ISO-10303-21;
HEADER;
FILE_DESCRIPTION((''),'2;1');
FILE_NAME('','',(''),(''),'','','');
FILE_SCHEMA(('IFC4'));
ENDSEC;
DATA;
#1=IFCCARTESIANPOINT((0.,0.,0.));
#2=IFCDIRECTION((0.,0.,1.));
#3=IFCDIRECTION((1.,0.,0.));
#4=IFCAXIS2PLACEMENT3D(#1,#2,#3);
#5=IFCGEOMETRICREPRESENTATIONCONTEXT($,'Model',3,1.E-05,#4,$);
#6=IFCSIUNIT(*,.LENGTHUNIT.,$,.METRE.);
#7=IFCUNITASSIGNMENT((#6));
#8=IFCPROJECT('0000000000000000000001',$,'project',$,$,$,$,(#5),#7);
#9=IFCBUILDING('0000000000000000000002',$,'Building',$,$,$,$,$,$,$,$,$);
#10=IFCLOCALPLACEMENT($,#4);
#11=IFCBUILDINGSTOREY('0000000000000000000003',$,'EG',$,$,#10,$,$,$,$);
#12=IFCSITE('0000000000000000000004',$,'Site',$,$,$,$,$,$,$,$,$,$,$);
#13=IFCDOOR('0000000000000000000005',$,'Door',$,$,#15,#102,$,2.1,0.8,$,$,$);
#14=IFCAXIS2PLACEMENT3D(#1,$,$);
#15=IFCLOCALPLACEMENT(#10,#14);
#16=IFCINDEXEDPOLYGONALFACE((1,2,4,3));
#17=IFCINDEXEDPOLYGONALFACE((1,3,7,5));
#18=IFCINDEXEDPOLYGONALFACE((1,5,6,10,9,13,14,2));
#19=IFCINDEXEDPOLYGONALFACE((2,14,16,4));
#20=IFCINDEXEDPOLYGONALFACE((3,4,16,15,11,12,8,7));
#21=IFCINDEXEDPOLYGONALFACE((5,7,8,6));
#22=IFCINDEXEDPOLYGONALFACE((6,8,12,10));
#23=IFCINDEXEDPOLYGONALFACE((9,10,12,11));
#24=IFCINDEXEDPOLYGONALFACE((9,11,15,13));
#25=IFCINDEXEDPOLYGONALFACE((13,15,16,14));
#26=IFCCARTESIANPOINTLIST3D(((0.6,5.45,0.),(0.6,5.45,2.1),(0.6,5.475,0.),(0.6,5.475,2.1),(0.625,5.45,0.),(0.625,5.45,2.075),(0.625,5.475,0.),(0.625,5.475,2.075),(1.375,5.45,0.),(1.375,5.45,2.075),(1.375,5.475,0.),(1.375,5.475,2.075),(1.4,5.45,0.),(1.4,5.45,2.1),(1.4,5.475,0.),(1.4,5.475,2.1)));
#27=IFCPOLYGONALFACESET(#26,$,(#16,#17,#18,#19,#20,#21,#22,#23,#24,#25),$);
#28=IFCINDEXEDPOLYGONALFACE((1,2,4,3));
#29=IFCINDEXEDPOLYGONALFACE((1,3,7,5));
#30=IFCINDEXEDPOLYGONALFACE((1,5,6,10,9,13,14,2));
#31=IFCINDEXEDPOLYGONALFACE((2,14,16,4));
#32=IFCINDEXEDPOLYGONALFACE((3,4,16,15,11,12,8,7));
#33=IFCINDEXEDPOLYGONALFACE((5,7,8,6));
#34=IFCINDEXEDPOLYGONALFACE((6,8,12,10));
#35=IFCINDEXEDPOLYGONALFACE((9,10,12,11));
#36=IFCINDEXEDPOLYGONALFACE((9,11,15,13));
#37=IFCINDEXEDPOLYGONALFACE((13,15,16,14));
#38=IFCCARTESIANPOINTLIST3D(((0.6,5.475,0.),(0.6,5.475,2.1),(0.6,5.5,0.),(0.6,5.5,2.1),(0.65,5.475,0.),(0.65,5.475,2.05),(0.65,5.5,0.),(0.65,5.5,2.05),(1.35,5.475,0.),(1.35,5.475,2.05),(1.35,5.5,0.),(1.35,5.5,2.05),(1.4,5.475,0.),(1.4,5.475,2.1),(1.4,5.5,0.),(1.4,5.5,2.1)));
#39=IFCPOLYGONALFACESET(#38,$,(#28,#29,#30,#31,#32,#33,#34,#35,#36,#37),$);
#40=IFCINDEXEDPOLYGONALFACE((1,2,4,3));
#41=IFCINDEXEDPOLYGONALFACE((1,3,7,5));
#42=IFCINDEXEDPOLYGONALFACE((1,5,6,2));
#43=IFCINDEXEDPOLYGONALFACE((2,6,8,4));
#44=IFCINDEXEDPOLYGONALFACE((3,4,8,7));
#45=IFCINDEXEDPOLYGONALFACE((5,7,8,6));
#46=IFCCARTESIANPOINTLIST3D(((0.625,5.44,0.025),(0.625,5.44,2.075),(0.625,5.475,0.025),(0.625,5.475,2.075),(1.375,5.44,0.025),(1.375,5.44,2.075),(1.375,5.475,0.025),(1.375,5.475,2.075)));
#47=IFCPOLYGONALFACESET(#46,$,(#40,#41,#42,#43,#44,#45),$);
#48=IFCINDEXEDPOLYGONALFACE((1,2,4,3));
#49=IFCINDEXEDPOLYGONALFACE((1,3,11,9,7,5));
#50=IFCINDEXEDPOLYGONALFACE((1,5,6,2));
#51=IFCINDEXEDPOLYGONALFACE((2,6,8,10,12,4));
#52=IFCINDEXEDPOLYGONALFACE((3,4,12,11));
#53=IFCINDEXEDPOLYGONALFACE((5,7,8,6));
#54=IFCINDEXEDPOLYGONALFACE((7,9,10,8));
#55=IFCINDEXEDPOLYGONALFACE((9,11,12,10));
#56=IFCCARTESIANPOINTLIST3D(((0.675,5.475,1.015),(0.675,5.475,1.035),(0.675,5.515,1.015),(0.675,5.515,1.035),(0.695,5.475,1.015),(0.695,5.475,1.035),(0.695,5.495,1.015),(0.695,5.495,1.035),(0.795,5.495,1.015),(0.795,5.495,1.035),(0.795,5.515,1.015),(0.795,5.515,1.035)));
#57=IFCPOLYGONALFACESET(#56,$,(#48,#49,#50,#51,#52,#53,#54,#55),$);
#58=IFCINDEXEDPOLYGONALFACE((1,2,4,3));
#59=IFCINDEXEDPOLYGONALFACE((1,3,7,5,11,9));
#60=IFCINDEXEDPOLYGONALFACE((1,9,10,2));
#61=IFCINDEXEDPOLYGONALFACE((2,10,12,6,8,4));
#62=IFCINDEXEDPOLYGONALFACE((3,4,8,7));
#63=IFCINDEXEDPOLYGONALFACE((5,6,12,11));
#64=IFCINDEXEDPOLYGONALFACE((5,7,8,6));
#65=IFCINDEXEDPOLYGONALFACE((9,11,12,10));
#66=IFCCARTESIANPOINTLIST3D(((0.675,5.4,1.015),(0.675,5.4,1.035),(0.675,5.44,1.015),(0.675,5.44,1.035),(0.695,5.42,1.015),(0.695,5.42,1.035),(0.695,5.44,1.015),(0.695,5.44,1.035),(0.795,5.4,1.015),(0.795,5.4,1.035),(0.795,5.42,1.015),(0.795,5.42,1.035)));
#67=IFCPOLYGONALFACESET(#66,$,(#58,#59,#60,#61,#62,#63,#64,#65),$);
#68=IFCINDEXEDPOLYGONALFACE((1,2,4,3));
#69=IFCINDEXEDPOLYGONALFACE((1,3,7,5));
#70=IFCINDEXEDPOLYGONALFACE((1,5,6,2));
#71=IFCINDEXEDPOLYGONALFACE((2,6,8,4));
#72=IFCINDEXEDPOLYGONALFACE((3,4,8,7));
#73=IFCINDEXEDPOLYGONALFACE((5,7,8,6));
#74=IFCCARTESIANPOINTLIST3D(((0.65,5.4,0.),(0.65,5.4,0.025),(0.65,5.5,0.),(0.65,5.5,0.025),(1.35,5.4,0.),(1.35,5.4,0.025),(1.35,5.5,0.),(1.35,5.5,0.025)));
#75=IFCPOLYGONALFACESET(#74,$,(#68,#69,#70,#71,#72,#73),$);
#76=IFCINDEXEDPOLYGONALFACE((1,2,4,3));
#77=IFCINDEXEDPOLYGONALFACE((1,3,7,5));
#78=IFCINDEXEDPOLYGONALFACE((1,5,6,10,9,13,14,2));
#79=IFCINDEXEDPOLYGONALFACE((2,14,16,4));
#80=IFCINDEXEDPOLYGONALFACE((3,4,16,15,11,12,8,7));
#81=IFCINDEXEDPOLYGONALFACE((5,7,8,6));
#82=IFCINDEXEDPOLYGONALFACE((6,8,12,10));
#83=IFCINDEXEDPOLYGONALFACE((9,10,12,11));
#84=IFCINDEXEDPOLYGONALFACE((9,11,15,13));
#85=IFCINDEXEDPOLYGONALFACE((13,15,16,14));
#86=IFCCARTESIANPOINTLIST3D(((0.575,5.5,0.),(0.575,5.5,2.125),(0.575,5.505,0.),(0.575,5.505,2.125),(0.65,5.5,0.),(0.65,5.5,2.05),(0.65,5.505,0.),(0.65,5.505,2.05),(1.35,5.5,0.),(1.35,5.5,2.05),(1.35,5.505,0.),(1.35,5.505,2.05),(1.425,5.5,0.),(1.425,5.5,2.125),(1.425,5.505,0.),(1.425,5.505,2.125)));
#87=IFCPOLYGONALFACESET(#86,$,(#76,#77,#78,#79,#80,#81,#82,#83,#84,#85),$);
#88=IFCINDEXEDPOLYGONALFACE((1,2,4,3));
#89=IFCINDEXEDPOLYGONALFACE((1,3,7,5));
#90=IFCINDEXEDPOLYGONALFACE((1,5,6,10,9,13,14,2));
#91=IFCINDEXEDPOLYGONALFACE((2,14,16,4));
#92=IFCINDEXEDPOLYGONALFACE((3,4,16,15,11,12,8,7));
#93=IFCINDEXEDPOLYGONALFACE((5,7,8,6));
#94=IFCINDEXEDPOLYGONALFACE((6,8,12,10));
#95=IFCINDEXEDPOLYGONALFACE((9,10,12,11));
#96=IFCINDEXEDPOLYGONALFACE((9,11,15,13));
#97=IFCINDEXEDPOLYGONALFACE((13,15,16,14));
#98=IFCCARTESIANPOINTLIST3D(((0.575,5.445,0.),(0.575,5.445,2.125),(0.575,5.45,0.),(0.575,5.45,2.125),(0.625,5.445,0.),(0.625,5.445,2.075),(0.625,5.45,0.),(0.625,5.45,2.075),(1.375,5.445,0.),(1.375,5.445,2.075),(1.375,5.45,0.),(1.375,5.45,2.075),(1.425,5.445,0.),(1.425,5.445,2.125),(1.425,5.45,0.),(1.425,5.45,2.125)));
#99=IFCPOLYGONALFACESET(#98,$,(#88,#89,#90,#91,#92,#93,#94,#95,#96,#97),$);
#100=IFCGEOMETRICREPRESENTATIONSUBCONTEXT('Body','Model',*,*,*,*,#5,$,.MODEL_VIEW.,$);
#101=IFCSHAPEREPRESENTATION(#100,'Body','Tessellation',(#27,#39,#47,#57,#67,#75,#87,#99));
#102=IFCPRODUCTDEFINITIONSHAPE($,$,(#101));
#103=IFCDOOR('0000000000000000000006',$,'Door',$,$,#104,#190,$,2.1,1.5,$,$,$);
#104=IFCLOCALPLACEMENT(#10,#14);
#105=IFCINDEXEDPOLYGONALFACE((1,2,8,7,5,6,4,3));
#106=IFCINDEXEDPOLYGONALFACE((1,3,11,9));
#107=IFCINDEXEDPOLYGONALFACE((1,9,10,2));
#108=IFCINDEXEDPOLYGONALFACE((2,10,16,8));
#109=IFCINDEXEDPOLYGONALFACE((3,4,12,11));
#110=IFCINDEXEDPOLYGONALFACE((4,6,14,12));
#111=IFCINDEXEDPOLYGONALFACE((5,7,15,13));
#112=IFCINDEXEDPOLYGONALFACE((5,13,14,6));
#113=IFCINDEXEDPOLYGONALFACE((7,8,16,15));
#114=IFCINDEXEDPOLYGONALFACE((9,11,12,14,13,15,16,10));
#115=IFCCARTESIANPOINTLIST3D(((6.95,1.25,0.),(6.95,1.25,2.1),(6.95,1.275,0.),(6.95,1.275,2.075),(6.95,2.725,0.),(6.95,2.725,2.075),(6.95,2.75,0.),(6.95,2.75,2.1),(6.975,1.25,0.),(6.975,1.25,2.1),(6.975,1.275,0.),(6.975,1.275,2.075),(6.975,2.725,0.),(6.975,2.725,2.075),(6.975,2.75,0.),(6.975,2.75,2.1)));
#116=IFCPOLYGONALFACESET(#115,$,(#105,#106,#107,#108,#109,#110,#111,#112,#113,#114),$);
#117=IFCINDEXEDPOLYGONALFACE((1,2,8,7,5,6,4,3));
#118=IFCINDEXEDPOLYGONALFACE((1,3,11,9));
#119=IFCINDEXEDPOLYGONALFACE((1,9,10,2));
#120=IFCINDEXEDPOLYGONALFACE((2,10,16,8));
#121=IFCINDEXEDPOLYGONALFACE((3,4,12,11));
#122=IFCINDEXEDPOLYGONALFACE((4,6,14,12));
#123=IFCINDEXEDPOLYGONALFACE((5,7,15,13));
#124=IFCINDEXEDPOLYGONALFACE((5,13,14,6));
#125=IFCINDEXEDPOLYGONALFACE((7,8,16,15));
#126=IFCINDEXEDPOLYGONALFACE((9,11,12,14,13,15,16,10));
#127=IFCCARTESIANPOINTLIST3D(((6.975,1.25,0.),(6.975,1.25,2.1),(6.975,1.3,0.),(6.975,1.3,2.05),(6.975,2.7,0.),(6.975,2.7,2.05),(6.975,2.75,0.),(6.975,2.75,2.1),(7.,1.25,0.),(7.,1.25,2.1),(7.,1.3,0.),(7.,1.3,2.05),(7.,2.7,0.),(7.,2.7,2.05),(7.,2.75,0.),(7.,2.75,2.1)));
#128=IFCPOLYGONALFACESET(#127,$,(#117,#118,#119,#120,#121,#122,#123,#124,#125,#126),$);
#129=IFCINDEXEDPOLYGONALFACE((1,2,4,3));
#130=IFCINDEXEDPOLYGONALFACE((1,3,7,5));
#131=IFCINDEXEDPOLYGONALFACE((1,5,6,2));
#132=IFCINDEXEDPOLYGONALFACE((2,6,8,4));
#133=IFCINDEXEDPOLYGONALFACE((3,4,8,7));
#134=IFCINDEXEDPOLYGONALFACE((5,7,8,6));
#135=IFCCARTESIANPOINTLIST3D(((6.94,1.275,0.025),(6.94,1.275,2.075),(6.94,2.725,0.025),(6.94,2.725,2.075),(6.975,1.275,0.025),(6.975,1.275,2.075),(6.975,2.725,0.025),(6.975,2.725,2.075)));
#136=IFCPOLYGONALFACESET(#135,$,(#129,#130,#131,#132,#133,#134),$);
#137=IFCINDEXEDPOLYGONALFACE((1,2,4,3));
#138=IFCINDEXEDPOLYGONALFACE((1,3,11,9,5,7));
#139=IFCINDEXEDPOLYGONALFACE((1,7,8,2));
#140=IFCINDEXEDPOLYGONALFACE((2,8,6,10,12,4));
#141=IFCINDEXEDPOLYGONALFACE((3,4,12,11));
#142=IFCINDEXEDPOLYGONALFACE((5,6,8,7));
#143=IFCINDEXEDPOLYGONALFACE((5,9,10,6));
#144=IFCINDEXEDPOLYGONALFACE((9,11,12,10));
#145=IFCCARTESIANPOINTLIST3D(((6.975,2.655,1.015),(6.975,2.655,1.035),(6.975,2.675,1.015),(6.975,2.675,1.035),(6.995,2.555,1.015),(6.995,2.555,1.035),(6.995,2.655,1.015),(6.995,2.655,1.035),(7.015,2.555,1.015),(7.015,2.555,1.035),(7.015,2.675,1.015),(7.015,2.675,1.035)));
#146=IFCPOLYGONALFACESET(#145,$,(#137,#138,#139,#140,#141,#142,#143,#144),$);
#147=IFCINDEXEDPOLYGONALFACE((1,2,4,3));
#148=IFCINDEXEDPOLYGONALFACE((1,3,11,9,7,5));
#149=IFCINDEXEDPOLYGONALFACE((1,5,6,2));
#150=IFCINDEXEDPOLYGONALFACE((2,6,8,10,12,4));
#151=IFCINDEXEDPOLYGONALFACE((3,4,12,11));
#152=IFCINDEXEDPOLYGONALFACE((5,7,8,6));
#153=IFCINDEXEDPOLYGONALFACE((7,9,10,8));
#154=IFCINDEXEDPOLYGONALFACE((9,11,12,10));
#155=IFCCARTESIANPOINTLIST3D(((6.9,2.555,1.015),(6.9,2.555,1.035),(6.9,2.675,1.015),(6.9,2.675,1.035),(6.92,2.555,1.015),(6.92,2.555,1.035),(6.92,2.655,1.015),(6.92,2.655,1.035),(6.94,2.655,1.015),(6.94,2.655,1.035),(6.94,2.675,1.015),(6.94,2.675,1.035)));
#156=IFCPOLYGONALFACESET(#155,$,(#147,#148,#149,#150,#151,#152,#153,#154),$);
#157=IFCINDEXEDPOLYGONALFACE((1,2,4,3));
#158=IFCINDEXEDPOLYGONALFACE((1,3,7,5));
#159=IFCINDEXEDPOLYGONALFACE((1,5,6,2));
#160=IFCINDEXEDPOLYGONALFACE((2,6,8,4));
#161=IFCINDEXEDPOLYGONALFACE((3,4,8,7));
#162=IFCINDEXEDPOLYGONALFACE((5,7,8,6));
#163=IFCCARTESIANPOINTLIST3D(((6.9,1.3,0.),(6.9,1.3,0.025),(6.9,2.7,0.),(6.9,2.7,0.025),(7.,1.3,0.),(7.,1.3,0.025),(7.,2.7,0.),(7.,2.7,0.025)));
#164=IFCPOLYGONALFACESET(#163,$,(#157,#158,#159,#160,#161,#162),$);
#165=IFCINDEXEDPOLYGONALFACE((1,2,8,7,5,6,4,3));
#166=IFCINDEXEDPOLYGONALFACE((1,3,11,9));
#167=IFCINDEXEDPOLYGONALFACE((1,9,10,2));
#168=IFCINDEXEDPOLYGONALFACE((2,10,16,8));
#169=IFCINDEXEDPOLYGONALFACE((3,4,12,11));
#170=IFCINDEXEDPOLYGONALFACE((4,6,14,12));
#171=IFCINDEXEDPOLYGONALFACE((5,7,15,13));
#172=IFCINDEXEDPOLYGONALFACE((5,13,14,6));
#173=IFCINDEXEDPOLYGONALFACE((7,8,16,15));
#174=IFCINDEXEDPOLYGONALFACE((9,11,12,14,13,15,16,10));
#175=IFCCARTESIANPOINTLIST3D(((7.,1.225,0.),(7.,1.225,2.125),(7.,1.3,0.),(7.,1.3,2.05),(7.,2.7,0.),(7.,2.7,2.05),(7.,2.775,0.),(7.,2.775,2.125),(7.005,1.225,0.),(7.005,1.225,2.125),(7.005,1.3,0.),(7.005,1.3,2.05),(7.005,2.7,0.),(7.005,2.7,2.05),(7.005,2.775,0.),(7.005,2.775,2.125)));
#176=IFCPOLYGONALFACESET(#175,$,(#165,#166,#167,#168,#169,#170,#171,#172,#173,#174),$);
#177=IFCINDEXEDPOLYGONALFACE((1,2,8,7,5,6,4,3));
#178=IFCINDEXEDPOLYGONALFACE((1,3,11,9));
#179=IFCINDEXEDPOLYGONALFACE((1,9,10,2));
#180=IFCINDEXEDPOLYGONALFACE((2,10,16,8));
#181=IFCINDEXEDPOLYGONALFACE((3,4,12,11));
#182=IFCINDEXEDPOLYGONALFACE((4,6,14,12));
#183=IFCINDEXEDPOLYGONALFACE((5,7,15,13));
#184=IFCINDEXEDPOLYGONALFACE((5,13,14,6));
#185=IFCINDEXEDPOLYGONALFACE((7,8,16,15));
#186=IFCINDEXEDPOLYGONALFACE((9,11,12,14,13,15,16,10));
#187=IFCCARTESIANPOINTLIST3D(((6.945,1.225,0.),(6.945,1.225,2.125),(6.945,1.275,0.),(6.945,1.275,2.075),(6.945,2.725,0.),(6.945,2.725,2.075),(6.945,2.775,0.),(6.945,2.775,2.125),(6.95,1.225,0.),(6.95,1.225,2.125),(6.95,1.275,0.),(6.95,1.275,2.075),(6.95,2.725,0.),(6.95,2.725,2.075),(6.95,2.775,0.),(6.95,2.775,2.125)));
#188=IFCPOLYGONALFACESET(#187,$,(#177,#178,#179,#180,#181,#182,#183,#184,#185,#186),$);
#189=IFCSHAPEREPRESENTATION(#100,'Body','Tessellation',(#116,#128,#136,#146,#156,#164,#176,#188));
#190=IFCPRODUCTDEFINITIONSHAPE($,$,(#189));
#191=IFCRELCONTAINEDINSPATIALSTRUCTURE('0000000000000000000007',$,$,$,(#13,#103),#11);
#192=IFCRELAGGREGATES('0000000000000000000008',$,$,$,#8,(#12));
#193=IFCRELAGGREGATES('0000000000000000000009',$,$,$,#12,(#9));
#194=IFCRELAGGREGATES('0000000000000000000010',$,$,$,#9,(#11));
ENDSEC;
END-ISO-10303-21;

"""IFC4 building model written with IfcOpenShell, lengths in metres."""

from ifc_helpers import new_model, si_unit, frame, origin_with_axes, place, context, subcontext, project, spatial, line, indexed_curve, outline, extrude, element, save


model = new_model("IFC4")

# Units and contexts
model_context = context("Model", 3, precision=1e-05, world=origin_with_axes())
body_context = subcontext(model_context, "Body", "Model", "MODEL_VIEW")
ifc_project = project(units=[si_unit("LENGTHUNIT", "METRE")], contexts=[model_context])

# Site, building, storey
site = spatial("IfcSite", under=ifc_project, Name="Site")
building = spatial("IfcBuilding", under=site, Name="Building")
storey_placement = place(None, origin_with_axes())
storey = spatial("IfcBuildingStorey", under=building, at=storey_placement, Name="EG")

# Doors
door_1_placement = place(storey_placement, frame((1.4, 5.5, 0.0), z_axis=(0.0, 0.0, 1.0), x_axis=(-1.0, 0.0, 0.0)))
element("IfcDoor", 1, at=door_1_placement, inside=storey, Name="Door", OverallHeight=2.1, OverallWidth=0.8, context=body_context, shape_type="SweptSolid", body=[
    extrude(outline(indexed_curve([(0.0, 0.0), (0.0, 2.1), (0.8, 2.1), (0.8, 0.0), (0.775, 0.0), (0.775, 2.075), (0.025, 2.075), (0.025, 0.0)], segments=[line(1, 2, 3, 4, 5, 6, 7, 8, 1)])), frame((0.0, 0.025, 0.0), z_axis=(0.0, -1.0, 0.0), x_axis=(1.0, 0.0, 0.0)), (0.0, 0.0, -1.0), 0.025),
    extrude(outline(indexed_curve([(0.0, 0.0), (0.0, 2.1), (0.8, 2.1), (0.8, 0.0), (0.75, 0.0), (0.75, 2.05), (0.05, 2.05), (0.05, 0.0)], segments=[line(1, 2, 3, 4, 5, 6, 7, 8, 1)])), frame((0.0, 0.0, 0.0), z_axis=(0.0, -1.0, 0.0), x_axis=(1.0, 0.0, 0.0)), (0.0, 0.0, -1.0), 0.025),
    extrude(outline(indexed_curve([(0.0, 0.0), (0.75, 0.0), (0.75, 0.035), (0.0, 0.035)], segments=[line(1, 2, 3, 4, 1)])), frame((0.025, 0.025, 0.025), z_axis=(0.0, 0.0, 1.0), x_axis=(1.0, 0.0, 0.0)), (0.0, 0.0, 1.0), 2.05),
    extrude(outline(indexed_curve([(0.0, 0.0), (0.0, -0.04), (-0.12, -0.04), (-0.12, -0.02), (-0.02, -0.02), (-0.02, 0.0)], segments=[line(1, 2, 3, 4, 5, 6, 1)])), frame((0.725, 0.025, 1.015), z_axis=(0.0, 0.0, 1.0), x_axis=(1.0, 0.0, 0.0)), (0.0, 0.0, 1.0), 0.02),
    extrude(outline(indexed_curve([(0.0, 0.0), (0.0, 0.04), (-0.12, 0.04), (-0.12, 0.02), (-0.02, 0.02), (-0.02, 0.0)], segments=[line(1, 2, 3, 4, 5, 6, 1)])), frame((0.725, 0.06, 1.015), z_axis=(0.0, 0.0, 1.0), x_axis=(1.0, 0.0, 0.0)), (0.0, 0.0, 1.0), 0.02),
    extrude(outline(indexed_curve([(0.0, 0.0), (0.7, 0.0), (0.7, 0.1), (0.0, 0.1)], segments=[line(1, 2, 3, 4, 1)])), frame((0.05, 0.0, 0.0), z_axis=(0.0, 0.0, 1.0), x_axis=(1.0, 0.0, 0.0)), (0.0, 0.0, 1.0), 0.025),
    extrude(outline(indexed_curve([(0.0, 0.0), (0.0, 2.125), (0.85, 2.125), (0.85, 0.0), (0.775, 0.0), (0.775, 2.05), (0.075, 2.05), (0.075, 0.0)], segments=[line(1, 2, 3, 4, 5, 6, 7, 8, 1)])), frame((-0.025, -0.005, 0.0), z_axis=(0.0, -1.0, 0.0), x_axis=(1.0, 0.0, 0.0)), (0.0, 0.0, -1.0), 0.005),
    extrude(outline(indexed_curve([(0.0, 0.0), (0.0, 2.125), (0.85, 2.125), (0.85, 0.0), (0.8, 0.0), (0.8, 2.075), (0.05, 2.075), (0.05, 0.0)], segments=[line(1, 2, 3, 4, 5, 6, 7, 8, 1)])), frame((-0.025, 0.05, 0.0), z_axis=(0.0, -1.0, 0.0), x_axis=(1.0, 0.0, 0.0)), (0.0, 0.0, -1.0), 0.005),
])
door_2_placement = place(storey_placement, frame((7.0, 1.25, 0.0), z_axis=(0.0, 0.0, 1.0), x_axis=(0.0, 1.0, 0.0)))
element("IfcDoor", 2, at=door_2_placement, inside=storey, Name="Door", OverallHeight=2.1, OverallWidth=1.5, context=body_context, shape_type="SweptSolid", body=[
    extrude(outline(indexed_curve([(0.0, 0.0), (0.0, 2.1), (1.5, 2.1), (1.5, 0.0), (1.475, 0.0), (1.475, 2.075), (0.025, 2.075), (0.025, 0.0)], segments=[line(1, 2, 3, 4, 5, 6, 7, 8, 1)])), frame((0.0, 0.025, 0.0), z_axis=(0.0, -1.0, 0.0), x_axis=(1.0, 0.0, 0.0)), (0.0, 0.0, -1.0), 0.025),
    extrude(outline(indexed_curve([(0.0, 0.0), (0.0, 2.1), (1.5, 2.1), (1.5, 0.0), (1.45, 0.0), (1.45, 2.05), (0.05, 2.05), (0.05, 0.0)], segments=[line(1, 2, 3, 4, 5, 6, 7, 8, 1)])), frame((0.0, 0.0, 0.0), z_axis=(0.0, -1.0, 0.0), x_axis=(1.0, 0.0, 0.0)), (0.0, 0.0, -1.0), 0.025),
    extrude(outline(indexed_curve([(0.0, 0.0), (1.45, 0.0), (1.45, 0.035), (0.0, 0.035)], segments=[line(1, 2, 3, 4, 1)])), frame((0.025, 0.025, 0.025), z_axis=(0.0, 0.0, 1.0), x_axis=(1.0, 0.0, 0.0)), (0.0, 0.0, 1.0), 2.05),
    extrude(outline(indexed_curve([(0.0, 0.0), (0.0, -0.04), (-0.12, -0.04), (-0.12, -0.02), (-0.02, -0.02), (-0.02, 0.0)], segments=[line(1, 2, 3, 4, 5, 6, 1)])), frame((1.425, 0.025, 1.015), z_axis=(0.0, 0.0, 1.0), x_axis=(1.0, 0.0, 0.0)), (0.0, 0.0, 1.0), 0.02),
    extrude(outline(indexed_curve([(0.0, 0.0), (0.0, 0.04), (-0.12, 0.04), (-0.12, 0.02), (-0.02, 0.02), (-0.02, 0.0)], segments=[line(1, 2, 3, 4, 5, 6, 1)])), frame((1.425, 0.06, 1.015), z_axis=(0.0, 0.0, 1.0), x_axis=(1.0, 0.0, 0.0)), (0.0, 0.0, 1.0), 0.02),
    extrude(outline(indexed_curve([(0.0, 0.0), (1.4, 0.0), (1.4, 0.1), (0.0, 0.1)], segments=[line(1, 2, 3, 4, 1)])), frame((0.05, 0.0, 0.0), z_axis=(0.0, 0.0, 1.0), x_axis=(1.0, 0.0, 0.0)), (0.0, 0.0, 1.0), 0.025),
    extrude(outline(indexed_curve([(0.0, 0.0), (0.0, 2.125), (1.55, 2.125), (1.55, 0.0), (1.475, 0.0), (1.475, 2.05), (0.075, 2.05), (0.075, 0.0)], segments=[line(1, 2, 3, 4, 5, 6, 7, 8, 1)])), frame((-0.025, -0.005, 0.0), z_axis=(0.0, -1.0, 0.0), x_axis=(1.0, 0.0, 0.0)), (0.0, 0.0, -1.0), 0.005),
    extrude(outline(indexed_curve([(0.0, 0.0), (0.0, 2.125), (1.55, 2.125), (1.55, 0.0), (1.5, 0.0), (1.5, 2.075), (0.05, 2.075), (0.05, 0.0)], segments=[line(1, 2, 3, 4, 5, 6, 7, 8, 1)])), frame((-0.025, 0.05, 0.0), z_axis=(0.0, -1.0, 0.0), x_axis=(1.0, 0.0, 0.0)), (0.0, 0.0, -1.0), 0.005),
])

save(model, "model.ifc")
